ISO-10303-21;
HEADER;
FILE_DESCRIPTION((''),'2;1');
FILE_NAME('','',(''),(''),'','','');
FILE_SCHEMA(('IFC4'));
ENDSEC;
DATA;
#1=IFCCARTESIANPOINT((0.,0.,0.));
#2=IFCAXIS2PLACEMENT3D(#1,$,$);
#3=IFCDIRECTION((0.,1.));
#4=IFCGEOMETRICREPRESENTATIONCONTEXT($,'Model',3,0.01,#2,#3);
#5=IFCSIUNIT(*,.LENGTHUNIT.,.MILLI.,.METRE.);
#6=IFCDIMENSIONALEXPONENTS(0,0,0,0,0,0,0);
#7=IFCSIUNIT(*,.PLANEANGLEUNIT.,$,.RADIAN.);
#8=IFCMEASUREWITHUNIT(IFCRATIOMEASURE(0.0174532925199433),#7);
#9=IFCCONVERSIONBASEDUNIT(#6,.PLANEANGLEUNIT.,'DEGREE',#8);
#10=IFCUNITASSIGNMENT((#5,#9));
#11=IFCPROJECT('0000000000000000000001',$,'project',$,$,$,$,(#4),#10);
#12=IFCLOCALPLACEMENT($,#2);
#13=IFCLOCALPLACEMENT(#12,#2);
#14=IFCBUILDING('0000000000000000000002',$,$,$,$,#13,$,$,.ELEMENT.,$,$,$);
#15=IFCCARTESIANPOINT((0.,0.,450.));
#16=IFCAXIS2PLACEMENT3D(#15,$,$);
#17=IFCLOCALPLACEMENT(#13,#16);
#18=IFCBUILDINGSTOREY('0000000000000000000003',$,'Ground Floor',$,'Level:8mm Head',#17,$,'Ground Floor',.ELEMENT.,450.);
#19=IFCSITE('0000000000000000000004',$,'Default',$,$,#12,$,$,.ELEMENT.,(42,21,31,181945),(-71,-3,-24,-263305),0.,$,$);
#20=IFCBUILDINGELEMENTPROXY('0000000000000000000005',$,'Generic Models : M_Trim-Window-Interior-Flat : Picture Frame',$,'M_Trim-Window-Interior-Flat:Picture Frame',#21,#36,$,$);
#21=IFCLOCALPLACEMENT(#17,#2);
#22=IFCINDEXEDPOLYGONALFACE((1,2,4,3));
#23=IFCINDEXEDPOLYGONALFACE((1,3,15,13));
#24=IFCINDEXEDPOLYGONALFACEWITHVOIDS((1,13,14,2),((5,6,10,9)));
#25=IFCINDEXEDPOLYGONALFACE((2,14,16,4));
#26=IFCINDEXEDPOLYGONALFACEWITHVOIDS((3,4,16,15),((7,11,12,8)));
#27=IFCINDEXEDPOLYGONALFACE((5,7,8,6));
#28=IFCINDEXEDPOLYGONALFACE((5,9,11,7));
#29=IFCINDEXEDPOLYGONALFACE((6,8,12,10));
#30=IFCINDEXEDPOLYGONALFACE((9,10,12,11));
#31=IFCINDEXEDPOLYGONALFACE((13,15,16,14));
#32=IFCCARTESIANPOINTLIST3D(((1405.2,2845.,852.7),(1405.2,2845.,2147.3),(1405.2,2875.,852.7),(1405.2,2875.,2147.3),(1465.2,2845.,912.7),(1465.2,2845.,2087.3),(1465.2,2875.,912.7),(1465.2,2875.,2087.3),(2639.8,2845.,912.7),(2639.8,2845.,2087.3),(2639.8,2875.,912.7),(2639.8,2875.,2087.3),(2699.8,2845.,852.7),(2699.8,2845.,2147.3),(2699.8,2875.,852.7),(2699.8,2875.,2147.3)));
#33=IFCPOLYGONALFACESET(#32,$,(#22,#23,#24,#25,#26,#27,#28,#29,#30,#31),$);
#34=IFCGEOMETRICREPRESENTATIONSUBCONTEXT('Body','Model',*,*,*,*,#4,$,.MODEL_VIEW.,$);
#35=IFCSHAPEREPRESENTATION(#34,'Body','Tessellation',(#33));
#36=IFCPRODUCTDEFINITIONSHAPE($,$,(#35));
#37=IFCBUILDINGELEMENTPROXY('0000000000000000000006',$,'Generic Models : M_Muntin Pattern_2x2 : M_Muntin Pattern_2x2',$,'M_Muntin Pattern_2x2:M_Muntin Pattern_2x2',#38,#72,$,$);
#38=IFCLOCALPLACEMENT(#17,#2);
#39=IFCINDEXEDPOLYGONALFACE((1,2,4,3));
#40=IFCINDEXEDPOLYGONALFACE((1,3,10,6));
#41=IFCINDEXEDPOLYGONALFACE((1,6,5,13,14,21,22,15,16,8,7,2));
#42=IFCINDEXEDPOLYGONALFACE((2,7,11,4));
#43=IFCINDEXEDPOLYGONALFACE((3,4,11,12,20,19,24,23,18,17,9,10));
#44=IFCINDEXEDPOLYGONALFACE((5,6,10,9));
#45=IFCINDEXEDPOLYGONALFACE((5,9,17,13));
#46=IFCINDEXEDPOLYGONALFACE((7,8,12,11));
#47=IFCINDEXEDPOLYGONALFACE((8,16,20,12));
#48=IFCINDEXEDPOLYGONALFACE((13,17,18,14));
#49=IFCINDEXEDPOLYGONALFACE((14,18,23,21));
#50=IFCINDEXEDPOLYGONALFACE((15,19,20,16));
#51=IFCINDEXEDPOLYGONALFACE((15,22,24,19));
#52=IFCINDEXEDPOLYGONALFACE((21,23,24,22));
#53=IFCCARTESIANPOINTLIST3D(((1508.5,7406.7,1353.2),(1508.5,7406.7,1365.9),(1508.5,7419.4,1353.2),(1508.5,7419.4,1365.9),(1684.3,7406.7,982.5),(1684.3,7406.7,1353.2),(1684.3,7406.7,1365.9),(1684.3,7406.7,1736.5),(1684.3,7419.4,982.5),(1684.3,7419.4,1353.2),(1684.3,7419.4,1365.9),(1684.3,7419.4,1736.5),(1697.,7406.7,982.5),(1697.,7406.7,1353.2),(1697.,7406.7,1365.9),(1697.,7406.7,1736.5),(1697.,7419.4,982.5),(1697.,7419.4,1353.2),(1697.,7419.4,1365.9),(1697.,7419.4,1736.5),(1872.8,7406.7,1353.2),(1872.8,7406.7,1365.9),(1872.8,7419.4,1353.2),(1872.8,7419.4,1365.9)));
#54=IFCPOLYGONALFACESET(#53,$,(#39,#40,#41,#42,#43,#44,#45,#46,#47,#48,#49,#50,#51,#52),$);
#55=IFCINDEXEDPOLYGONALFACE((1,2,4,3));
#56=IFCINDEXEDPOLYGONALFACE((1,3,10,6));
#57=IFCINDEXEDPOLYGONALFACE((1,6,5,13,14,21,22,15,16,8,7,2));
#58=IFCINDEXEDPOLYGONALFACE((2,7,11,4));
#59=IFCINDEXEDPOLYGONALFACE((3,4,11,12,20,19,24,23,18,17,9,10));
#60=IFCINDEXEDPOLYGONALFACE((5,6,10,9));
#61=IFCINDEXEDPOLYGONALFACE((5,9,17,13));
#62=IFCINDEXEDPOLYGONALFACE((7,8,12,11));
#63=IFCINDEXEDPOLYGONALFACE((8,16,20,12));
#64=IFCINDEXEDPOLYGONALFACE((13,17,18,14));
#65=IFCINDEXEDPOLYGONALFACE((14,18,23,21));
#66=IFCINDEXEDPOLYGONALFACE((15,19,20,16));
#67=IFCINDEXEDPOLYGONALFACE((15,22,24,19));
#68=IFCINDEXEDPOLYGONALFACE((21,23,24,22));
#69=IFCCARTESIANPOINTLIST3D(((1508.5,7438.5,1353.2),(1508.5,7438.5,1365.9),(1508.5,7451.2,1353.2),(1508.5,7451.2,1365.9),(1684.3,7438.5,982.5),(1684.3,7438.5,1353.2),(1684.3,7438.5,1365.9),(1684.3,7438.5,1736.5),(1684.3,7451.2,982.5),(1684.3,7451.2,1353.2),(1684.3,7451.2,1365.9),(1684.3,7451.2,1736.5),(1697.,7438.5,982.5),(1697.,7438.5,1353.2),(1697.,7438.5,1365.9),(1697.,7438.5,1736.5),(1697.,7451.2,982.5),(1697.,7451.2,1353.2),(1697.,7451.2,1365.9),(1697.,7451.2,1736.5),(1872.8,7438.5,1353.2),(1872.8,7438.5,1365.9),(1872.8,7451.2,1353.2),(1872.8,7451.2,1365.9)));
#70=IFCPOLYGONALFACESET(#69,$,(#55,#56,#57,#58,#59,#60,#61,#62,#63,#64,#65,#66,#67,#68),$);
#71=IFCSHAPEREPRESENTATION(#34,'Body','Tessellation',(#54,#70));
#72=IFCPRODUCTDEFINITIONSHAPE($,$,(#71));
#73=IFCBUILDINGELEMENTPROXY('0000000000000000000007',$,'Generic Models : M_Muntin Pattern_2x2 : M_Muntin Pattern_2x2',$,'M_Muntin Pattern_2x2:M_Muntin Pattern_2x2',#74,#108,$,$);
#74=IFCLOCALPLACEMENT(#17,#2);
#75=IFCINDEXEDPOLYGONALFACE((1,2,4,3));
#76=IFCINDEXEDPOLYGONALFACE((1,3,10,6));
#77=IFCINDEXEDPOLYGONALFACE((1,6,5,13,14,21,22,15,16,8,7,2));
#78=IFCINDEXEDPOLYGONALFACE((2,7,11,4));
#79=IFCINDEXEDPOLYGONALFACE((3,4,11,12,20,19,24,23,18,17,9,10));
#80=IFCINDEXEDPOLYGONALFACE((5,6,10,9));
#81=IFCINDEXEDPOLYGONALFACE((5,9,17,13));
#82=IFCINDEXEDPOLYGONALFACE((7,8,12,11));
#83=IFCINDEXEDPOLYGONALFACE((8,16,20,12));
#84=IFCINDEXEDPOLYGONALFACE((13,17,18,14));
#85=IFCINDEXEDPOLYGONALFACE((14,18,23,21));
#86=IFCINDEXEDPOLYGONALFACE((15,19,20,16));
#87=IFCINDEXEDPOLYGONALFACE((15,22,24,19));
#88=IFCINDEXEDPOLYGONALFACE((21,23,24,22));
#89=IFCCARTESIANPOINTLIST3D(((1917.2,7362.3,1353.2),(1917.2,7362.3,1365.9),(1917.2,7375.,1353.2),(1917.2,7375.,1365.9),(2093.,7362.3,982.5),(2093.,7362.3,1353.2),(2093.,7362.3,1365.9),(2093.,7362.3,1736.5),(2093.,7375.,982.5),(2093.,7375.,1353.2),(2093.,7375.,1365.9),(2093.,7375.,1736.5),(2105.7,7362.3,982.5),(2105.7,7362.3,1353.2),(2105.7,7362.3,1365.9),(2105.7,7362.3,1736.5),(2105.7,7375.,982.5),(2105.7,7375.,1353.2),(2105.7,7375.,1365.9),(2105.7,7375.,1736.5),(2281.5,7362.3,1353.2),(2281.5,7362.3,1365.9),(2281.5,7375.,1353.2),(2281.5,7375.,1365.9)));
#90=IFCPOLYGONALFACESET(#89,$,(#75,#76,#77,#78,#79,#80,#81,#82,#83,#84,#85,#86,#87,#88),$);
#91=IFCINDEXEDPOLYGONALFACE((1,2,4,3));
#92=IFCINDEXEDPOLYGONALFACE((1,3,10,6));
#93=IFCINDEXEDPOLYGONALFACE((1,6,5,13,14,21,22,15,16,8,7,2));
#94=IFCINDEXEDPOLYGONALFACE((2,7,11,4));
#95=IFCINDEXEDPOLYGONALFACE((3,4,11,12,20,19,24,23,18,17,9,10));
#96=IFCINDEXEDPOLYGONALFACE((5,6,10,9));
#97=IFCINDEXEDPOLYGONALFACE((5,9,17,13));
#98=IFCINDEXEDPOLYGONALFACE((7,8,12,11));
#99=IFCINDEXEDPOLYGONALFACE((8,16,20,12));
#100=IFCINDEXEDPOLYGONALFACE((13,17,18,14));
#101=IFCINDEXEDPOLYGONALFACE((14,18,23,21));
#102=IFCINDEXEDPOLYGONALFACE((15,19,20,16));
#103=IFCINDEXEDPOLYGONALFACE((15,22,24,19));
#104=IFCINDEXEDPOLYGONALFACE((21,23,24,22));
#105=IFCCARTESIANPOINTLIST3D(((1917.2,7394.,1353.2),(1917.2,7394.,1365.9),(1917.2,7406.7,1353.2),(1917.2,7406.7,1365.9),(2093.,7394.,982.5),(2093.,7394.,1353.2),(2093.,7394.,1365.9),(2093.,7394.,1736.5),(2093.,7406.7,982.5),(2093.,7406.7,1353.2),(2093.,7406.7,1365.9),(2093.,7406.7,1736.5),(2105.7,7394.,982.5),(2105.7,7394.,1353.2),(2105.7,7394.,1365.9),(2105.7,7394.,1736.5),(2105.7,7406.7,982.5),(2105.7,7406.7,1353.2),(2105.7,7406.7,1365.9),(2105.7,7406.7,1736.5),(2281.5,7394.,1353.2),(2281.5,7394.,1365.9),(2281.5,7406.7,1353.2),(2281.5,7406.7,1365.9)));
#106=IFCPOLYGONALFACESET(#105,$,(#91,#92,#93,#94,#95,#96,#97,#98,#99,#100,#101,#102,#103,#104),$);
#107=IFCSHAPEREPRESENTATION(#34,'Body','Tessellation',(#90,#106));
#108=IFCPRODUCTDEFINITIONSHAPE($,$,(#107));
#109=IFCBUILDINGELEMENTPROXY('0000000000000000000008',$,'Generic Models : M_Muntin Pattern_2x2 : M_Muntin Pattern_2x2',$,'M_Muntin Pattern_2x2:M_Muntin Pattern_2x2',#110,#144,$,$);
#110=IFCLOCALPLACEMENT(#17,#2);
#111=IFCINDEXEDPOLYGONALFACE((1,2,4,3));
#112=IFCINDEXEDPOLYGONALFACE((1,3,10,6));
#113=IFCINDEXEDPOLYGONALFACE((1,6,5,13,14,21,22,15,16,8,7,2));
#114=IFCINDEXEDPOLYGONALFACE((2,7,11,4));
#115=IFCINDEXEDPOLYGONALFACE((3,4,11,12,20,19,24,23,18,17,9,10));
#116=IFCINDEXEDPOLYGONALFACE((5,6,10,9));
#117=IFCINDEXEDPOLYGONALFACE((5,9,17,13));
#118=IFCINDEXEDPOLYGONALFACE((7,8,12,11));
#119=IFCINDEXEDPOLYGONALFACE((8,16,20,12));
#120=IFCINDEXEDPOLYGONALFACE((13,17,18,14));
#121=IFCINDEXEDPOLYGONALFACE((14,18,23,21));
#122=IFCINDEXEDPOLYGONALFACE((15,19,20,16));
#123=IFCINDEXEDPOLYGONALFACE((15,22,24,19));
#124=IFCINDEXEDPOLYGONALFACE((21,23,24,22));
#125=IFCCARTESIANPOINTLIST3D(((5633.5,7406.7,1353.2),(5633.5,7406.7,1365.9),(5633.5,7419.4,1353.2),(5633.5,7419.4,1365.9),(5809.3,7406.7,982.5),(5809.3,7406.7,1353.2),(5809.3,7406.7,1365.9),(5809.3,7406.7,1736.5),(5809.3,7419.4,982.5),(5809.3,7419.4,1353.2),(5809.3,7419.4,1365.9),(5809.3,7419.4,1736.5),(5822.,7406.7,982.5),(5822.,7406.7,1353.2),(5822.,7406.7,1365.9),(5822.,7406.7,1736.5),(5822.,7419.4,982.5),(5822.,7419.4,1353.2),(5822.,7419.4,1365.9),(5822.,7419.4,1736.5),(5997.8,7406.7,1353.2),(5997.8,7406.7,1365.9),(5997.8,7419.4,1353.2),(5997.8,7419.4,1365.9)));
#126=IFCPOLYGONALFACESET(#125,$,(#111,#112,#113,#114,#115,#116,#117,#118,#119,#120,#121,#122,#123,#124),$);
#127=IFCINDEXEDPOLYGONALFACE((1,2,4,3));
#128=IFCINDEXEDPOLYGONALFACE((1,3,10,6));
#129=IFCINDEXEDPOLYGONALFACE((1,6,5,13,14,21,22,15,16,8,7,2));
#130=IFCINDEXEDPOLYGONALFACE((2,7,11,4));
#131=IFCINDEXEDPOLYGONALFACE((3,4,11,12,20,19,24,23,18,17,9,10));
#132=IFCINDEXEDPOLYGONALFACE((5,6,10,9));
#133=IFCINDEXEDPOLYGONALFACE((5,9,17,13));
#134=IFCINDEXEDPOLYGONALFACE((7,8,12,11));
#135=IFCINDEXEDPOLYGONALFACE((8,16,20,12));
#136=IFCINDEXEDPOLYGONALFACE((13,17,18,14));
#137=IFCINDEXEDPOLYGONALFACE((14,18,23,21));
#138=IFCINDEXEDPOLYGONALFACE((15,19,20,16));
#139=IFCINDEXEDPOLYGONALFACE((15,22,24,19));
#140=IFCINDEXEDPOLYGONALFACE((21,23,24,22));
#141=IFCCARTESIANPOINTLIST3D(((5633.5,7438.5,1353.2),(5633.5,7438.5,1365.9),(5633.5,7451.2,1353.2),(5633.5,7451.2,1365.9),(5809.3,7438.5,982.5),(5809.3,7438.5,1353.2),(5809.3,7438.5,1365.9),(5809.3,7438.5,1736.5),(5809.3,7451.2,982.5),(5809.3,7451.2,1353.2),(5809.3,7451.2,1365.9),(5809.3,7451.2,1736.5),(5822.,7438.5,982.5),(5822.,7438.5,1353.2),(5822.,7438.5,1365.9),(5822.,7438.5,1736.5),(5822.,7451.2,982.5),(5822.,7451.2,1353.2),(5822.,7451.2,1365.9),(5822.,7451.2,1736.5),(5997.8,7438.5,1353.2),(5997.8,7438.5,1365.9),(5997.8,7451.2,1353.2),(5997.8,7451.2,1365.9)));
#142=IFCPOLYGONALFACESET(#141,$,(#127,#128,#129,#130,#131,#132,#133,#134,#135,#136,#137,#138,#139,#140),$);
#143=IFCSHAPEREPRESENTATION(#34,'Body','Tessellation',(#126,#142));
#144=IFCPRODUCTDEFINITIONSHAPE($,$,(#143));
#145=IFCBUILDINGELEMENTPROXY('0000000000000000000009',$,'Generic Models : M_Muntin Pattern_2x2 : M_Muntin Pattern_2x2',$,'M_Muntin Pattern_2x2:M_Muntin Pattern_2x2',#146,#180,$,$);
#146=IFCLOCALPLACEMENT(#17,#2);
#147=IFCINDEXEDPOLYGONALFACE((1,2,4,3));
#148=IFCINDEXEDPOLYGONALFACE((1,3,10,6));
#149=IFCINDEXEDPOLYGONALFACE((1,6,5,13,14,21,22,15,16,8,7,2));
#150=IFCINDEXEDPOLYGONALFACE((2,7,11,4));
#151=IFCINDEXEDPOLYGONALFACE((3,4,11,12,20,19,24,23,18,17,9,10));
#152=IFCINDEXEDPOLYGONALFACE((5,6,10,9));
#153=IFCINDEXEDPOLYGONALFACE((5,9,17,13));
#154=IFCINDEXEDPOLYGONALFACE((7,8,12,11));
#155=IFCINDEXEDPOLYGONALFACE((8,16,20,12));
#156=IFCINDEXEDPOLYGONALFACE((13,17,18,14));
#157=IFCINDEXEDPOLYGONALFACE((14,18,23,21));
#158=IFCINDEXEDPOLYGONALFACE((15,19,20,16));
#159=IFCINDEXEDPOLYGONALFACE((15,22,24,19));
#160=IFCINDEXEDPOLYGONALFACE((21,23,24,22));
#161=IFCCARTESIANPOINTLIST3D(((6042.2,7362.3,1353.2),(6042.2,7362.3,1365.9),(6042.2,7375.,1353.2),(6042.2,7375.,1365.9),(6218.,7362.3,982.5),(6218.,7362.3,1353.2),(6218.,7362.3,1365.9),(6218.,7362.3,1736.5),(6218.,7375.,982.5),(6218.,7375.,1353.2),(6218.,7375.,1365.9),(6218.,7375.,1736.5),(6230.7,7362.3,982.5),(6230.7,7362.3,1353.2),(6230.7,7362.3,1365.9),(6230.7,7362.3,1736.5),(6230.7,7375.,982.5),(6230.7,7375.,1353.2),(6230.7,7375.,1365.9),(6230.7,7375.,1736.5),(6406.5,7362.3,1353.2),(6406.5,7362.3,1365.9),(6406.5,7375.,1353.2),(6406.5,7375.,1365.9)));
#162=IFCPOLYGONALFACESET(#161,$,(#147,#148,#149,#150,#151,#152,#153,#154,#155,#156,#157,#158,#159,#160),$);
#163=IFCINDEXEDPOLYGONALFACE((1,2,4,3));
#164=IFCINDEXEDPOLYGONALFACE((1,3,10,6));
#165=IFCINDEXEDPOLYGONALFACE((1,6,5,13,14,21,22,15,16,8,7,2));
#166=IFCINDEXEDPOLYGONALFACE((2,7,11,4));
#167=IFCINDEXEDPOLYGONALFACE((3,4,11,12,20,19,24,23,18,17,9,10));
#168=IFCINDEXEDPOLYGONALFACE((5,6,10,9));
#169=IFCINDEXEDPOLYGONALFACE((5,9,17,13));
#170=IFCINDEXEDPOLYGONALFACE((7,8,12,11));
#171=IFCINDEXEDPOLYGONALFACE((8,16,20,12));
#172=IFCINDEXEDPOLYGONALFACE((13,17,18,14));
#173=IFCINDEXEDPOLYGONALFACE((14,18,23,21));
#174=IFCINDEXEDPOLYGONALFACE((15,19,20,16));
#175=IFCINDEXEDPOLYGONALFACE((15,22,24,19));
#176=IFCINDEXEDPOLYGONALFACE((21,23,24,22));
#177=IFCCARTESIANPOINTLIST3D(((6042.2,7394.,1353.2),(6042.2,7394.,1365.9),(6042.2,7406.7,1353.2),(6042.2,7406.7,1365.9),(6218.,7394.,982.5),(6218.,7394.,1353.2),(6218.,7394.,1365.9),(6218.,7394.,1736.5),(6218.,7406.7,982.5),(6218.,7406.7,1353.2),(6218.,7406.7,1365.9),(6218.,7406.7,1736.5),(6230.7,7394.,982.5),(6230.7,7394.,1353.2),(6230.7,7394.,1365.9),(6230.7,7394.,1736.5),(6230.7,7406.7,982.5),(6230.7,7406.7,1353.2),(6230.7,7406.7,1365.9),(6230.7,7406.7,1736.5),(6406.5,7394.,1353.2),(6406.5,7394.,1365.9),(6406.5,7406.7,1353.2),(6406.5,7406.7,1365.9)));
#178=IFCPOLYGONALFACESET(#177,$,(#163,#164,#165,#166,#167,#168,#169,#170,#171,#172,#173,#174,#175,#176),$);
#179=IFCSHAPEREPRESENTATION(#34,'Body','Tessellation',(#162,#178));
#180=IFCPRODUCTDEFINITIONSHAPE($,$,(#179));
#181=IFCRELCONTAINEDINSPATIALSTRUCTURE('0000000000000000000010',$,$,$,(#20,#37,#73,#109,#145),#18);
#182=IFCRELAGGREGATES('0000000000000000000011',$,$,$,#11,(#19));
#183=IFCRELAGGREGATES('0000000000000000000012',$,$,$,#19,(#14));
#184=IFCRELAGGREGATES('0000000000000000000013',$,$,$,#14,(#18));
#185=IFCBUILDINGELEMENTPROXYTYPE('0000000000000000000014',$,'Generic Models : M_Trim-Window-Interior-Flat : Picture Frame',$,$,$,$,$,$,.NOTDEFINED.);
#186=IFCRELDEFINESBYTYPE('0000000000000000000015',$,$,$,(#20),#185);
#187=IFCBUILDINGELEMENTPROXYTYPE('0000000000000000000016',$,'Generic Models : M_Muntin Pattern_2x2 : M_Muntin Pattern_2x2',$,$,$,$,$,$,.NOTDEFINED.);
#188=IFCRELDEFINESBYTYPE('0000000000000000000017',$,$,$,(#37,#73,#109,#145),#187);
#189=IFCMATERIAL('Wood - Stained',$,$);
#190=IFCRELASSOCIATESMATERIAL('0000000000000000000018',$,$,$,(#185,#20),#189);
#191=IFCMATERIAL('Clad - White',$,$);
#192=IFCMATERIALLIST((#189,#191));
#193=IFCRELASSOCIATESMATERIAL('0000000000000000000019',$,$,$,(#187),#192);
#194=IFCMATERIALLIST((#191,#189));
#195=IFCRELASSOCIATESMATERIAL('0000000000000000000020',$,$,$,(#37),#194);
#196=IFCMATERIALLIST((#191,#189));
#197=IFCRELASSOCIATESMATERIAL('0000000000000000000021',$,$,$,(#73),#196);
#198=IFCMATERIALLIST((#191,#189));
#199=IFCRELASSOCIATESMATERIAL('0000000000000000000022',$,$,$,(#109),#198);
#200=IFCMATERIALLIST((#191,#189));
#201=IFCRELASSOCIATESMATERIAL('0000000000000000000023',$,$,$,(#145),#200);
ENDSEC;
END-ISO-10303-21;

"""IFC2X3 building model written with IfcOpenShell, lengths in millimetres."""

from ifc_helpers import new_model, entity, si_unit, converted_unit, direction, frame, origin, place, context, subcontext, project, spatial, polyline, outline, extrude, source, transform, mapped, material, material_list, type_object, type_shapes, element, save


model = new_model("IFC2X3")

# Units and contexts
model_context = context("Model", 3, precision=0.01, world=origin(), true_north=direction((0.0, 1.0)))
body_context = subcontext(model_context, "Body", "Model", "MODEL_VIEW")
ifc_project = project(units=[si_unit("LENGTHUNIT", "METRE", prefix="MILLI"), converted_unit("PLANEANGLEUNIT", "DEGREE", entity("IfcRatioMeasure", 0.0174532925199433), si_unit("PLANEANGLEUNIT", "RADIAN"), dimensions=[0, 0, 0, 0, 0, 0, 0])], contexts=[model_context])

# Site, building, storey
site_placement = place(None, origin())
site = spatial("IfcSite", under=ifc_project, at=site_placement, Name="Default", CompositionType="ELEMENT", RefLatitude=(42, 21, 31, 181945), RefLongitude=(-71, -3, -24, -263305), RefElevation=0.0)
building_placement = place(site_placement, origin())
building = spatial("IfcBuilding", under=site, at=building_placement, CompositionType="ELEMENT")
storey_placement = place(building_placement, frame((0.0, 0.0, 450.0)))
storey = spatial("IfcBuildingStorey", under=building, at=storey_placement, Name="Ground Floor", ObjectType="Level:8mm Head", LongName="Ground Floor", CompositionType="ELEMENT", Elevation=450.0)

# Shared definitions
ifc_material_1 = material(Name="Clad - White")
ifc_material_2 = material(Name="Wood - Stained")

# Building element proxies
building_element_proxy_type_1 = type_object("IfcBuildingElementProxyType", Name="Generic Models : M_Trim-Window-Interior-Flat : Picture Frame", PredefinedType="NOTDEFINED", material=ifc_material_2)
shared_shape_1 = source(origin(), body_context, "Body", "SweptSolid", [
    extrude(outline(polyline([(-647.3, -647.3), (647.3, -647.3), (647.3, 647.3), (-647.3, 647.3), (-647.3, -647.3)]), holes=[polyline([(-587.3, -587.3), (-587.3, 587.3), (587.3, 587.3), (587.3, -587.3), (-587.3, -587.3)])]), frame((0.0, -600.0, 0.0), z_axis=(0.0, 0.0, 1.0), x_axis=(-1.0, 0.0, 0.0)), (0.0, 0.0, 1.0), 30.0),
])
type_shapes(building_element_proxy_type_1, [shared_shape_1])
proxy_1_placement = place(storey_placement, frame((2052.5, 2875.0, 2100.0), z_axis=(0.0, -1.0, 0.0), x_axis=(1.0, 0.0, 0.0)))
element("IfcBuildingElementProxy", 1, at=proxy_1_placement, inside=storey, type_object=building_element_proxy_type_1, material=ifc_material_2, Name="Generic Models : M_Trim-Window-Interior-Flat : Picture Frame", ObjectType="M_Trim-Window-Interior-Flat:Picture Frame", context=body_context, shape_type="MappedRepresentation", body=[
    mapped(shared_shape_1, transform((0.0, 0.0, 0.0), scale=1.0)),
])
ifc_material_list_1 = material_list([ifc_material_1, ifc_material_2])
ifc_material_list_2 = material_list([ifc_material_2, ifc_material_1])
building_element_proxy_type_2 = type_object("IfcBuildingElementProxyType", Name="Generic Models : M_Muntin Pattern_2x2 : M_Muntin Pattern_2x2", PredefinedType="NOTDEFINED", material=ifc_material_list_2)
shared_shape_2 = source(origin(), body_context, "Body", "SweptSolid", [
    extrude(outline(polyline([(6.4, -6.4), (377.0, -6.4), (377.0, 6.3), (6.4, 6.3), (6.4, 182.1), (-6.3, 182.1), (-6.3, 6.3), (-377.0, 6.3), (-377.0, -6.4), (-6.3, -6.4), (-6.3, -182.1), (6.4, -182.1), (6.4, -6.4)])), frame((0.0, 9.5, 377.0), z_axis=(0.0, 1.0, 0.0), x_axis=(0.0, 0.0, 1.0)), (0.0, 0.0, 1.0), 12.7),
    extrude(outline(polyline([(6.4, -6.4), (377.0, -6.4), (377.0, 6.3), (6.4, 6.3), (6.4, 182.1), (-6.3, 182.1), (-6.3, 6.3), (-377.0, 6.3), (-377.0, -6.4), (-6.3, -6.4), (-6.3, -182.1), (6.4, -182.1), (6.4, -6.4)])), frame((0.0, -22.2, 377.0), z_axis=(0.0, 1.0, 0.0), x_axis=(0.0, 0.0, 1.0)), (0.0, 0.0, 1.0), 12.7),
])
type_shapes(building_element_proxy_type_2, [shared_shape_2])
proxy_2_placement = place(storey_placement, frame((1690.6, 7429.0, 982.5), z_axis=(0.0, 0.0, 1.0), x_axis=(-1.0, 0.0, 0.0)))
element("IfcBuildingElementProxy", 2, at=proxy_2_placement, inside=storey, type_object=building_element_proxy_type_2, material=ifc_material_list_1, Name="Generic Models : M_Muntin Pattern_2x2 : M_Muntin Pattern_2x2", ObjectType="M_Muntin Pattern_2x2:M_Muntin Pattern_2x2", context=body_context, shape_type="MappedRepresentation", body=[
    mapped(shared_shape_2, transform((0.0, 0.0, 0.0), scale=1.0)),
])
ifc_material_list_3 = material_list([ifc_material_1, ifc_material_2])
proxy_3_placement = place(storey_placement, frame((2099.4, 7384.5, 982.5), z_axis=(0.0, 0.0, 1.0), x_axis=(-1.0, 0.0, 0.0)))
element("IfcBuildingElementProxy", 3, at=proxy_3_placement, inside=storey, type_object=building_element_proxy_type_2, material=ifc_material_list_3, Name="Generic Models : M_Muntin Pattern_2x2 : M_Muntin Pattern_2x2", ObjectType="M_Muntin Pattern_2x2:M_Muntin Pattern_2x2", context=body_context, shape_type="MappedRepresentation", body=[
    mapped(shared_shape_2, transform((0.0, 0.0, 0.0), scale=1.0)),
])
ifc_material_list_4 = material_list([ifc_material_1, ifc_material_2])
proxy_4_placement = place(storey_placement, frame((5815.6, 7429.0, 982.5), z_axis=(0.0, 0.0, 1.0), x_axis=(-1.0, 0.0, 0.0)))
element("IfcBuildingElementProxy", 4, at=proxy_4_placement, inside=storey, type_object=building_element_proxy_type_2, material=ifc_material_list_4, Name="Generic Models : M_Muntin Pattern_2x2 : M_Muntin Pattern_2x2", ObjectType="M_Muntin Pattern_2x2:M_Muntin Pattern_2x2", context=body_context, shape_type="MappedRepresentation", body=[
    mapped(shared_shape_2, transform((0.0, 0.0, 0.0), scale=1.0)),
])
ifc_material_list_5 = material_list([ifc_material_1, ifc_material_2])
proxy_5_placement = place(storey_placement, frame((6224.4, 7384.5, 982.5), z_axis=(0.0, 0.0, 1.0), x_axis=(-1.0, 0.0, 0.0)))
element("IfcBuildingElementProxy", 5, at=proxy_5_placement, inside=storey, type_object=building_element_proxy_type_2, material=ifc_material_list_5, Name="Generic Models : M_Muntin Pattern_2x2 : M_Muntin Pattern_2x2", ObjectType="M_Muntin Pattern_2x2:M_Muntin Pattern_2x2", context=body_context, shape_type="MappedRepresentation", body=[
    mapped(shared_shape_2, transform((0.0, 0.0, 0.0), scale=1.0)),
])

save(model, "model.ifc")
